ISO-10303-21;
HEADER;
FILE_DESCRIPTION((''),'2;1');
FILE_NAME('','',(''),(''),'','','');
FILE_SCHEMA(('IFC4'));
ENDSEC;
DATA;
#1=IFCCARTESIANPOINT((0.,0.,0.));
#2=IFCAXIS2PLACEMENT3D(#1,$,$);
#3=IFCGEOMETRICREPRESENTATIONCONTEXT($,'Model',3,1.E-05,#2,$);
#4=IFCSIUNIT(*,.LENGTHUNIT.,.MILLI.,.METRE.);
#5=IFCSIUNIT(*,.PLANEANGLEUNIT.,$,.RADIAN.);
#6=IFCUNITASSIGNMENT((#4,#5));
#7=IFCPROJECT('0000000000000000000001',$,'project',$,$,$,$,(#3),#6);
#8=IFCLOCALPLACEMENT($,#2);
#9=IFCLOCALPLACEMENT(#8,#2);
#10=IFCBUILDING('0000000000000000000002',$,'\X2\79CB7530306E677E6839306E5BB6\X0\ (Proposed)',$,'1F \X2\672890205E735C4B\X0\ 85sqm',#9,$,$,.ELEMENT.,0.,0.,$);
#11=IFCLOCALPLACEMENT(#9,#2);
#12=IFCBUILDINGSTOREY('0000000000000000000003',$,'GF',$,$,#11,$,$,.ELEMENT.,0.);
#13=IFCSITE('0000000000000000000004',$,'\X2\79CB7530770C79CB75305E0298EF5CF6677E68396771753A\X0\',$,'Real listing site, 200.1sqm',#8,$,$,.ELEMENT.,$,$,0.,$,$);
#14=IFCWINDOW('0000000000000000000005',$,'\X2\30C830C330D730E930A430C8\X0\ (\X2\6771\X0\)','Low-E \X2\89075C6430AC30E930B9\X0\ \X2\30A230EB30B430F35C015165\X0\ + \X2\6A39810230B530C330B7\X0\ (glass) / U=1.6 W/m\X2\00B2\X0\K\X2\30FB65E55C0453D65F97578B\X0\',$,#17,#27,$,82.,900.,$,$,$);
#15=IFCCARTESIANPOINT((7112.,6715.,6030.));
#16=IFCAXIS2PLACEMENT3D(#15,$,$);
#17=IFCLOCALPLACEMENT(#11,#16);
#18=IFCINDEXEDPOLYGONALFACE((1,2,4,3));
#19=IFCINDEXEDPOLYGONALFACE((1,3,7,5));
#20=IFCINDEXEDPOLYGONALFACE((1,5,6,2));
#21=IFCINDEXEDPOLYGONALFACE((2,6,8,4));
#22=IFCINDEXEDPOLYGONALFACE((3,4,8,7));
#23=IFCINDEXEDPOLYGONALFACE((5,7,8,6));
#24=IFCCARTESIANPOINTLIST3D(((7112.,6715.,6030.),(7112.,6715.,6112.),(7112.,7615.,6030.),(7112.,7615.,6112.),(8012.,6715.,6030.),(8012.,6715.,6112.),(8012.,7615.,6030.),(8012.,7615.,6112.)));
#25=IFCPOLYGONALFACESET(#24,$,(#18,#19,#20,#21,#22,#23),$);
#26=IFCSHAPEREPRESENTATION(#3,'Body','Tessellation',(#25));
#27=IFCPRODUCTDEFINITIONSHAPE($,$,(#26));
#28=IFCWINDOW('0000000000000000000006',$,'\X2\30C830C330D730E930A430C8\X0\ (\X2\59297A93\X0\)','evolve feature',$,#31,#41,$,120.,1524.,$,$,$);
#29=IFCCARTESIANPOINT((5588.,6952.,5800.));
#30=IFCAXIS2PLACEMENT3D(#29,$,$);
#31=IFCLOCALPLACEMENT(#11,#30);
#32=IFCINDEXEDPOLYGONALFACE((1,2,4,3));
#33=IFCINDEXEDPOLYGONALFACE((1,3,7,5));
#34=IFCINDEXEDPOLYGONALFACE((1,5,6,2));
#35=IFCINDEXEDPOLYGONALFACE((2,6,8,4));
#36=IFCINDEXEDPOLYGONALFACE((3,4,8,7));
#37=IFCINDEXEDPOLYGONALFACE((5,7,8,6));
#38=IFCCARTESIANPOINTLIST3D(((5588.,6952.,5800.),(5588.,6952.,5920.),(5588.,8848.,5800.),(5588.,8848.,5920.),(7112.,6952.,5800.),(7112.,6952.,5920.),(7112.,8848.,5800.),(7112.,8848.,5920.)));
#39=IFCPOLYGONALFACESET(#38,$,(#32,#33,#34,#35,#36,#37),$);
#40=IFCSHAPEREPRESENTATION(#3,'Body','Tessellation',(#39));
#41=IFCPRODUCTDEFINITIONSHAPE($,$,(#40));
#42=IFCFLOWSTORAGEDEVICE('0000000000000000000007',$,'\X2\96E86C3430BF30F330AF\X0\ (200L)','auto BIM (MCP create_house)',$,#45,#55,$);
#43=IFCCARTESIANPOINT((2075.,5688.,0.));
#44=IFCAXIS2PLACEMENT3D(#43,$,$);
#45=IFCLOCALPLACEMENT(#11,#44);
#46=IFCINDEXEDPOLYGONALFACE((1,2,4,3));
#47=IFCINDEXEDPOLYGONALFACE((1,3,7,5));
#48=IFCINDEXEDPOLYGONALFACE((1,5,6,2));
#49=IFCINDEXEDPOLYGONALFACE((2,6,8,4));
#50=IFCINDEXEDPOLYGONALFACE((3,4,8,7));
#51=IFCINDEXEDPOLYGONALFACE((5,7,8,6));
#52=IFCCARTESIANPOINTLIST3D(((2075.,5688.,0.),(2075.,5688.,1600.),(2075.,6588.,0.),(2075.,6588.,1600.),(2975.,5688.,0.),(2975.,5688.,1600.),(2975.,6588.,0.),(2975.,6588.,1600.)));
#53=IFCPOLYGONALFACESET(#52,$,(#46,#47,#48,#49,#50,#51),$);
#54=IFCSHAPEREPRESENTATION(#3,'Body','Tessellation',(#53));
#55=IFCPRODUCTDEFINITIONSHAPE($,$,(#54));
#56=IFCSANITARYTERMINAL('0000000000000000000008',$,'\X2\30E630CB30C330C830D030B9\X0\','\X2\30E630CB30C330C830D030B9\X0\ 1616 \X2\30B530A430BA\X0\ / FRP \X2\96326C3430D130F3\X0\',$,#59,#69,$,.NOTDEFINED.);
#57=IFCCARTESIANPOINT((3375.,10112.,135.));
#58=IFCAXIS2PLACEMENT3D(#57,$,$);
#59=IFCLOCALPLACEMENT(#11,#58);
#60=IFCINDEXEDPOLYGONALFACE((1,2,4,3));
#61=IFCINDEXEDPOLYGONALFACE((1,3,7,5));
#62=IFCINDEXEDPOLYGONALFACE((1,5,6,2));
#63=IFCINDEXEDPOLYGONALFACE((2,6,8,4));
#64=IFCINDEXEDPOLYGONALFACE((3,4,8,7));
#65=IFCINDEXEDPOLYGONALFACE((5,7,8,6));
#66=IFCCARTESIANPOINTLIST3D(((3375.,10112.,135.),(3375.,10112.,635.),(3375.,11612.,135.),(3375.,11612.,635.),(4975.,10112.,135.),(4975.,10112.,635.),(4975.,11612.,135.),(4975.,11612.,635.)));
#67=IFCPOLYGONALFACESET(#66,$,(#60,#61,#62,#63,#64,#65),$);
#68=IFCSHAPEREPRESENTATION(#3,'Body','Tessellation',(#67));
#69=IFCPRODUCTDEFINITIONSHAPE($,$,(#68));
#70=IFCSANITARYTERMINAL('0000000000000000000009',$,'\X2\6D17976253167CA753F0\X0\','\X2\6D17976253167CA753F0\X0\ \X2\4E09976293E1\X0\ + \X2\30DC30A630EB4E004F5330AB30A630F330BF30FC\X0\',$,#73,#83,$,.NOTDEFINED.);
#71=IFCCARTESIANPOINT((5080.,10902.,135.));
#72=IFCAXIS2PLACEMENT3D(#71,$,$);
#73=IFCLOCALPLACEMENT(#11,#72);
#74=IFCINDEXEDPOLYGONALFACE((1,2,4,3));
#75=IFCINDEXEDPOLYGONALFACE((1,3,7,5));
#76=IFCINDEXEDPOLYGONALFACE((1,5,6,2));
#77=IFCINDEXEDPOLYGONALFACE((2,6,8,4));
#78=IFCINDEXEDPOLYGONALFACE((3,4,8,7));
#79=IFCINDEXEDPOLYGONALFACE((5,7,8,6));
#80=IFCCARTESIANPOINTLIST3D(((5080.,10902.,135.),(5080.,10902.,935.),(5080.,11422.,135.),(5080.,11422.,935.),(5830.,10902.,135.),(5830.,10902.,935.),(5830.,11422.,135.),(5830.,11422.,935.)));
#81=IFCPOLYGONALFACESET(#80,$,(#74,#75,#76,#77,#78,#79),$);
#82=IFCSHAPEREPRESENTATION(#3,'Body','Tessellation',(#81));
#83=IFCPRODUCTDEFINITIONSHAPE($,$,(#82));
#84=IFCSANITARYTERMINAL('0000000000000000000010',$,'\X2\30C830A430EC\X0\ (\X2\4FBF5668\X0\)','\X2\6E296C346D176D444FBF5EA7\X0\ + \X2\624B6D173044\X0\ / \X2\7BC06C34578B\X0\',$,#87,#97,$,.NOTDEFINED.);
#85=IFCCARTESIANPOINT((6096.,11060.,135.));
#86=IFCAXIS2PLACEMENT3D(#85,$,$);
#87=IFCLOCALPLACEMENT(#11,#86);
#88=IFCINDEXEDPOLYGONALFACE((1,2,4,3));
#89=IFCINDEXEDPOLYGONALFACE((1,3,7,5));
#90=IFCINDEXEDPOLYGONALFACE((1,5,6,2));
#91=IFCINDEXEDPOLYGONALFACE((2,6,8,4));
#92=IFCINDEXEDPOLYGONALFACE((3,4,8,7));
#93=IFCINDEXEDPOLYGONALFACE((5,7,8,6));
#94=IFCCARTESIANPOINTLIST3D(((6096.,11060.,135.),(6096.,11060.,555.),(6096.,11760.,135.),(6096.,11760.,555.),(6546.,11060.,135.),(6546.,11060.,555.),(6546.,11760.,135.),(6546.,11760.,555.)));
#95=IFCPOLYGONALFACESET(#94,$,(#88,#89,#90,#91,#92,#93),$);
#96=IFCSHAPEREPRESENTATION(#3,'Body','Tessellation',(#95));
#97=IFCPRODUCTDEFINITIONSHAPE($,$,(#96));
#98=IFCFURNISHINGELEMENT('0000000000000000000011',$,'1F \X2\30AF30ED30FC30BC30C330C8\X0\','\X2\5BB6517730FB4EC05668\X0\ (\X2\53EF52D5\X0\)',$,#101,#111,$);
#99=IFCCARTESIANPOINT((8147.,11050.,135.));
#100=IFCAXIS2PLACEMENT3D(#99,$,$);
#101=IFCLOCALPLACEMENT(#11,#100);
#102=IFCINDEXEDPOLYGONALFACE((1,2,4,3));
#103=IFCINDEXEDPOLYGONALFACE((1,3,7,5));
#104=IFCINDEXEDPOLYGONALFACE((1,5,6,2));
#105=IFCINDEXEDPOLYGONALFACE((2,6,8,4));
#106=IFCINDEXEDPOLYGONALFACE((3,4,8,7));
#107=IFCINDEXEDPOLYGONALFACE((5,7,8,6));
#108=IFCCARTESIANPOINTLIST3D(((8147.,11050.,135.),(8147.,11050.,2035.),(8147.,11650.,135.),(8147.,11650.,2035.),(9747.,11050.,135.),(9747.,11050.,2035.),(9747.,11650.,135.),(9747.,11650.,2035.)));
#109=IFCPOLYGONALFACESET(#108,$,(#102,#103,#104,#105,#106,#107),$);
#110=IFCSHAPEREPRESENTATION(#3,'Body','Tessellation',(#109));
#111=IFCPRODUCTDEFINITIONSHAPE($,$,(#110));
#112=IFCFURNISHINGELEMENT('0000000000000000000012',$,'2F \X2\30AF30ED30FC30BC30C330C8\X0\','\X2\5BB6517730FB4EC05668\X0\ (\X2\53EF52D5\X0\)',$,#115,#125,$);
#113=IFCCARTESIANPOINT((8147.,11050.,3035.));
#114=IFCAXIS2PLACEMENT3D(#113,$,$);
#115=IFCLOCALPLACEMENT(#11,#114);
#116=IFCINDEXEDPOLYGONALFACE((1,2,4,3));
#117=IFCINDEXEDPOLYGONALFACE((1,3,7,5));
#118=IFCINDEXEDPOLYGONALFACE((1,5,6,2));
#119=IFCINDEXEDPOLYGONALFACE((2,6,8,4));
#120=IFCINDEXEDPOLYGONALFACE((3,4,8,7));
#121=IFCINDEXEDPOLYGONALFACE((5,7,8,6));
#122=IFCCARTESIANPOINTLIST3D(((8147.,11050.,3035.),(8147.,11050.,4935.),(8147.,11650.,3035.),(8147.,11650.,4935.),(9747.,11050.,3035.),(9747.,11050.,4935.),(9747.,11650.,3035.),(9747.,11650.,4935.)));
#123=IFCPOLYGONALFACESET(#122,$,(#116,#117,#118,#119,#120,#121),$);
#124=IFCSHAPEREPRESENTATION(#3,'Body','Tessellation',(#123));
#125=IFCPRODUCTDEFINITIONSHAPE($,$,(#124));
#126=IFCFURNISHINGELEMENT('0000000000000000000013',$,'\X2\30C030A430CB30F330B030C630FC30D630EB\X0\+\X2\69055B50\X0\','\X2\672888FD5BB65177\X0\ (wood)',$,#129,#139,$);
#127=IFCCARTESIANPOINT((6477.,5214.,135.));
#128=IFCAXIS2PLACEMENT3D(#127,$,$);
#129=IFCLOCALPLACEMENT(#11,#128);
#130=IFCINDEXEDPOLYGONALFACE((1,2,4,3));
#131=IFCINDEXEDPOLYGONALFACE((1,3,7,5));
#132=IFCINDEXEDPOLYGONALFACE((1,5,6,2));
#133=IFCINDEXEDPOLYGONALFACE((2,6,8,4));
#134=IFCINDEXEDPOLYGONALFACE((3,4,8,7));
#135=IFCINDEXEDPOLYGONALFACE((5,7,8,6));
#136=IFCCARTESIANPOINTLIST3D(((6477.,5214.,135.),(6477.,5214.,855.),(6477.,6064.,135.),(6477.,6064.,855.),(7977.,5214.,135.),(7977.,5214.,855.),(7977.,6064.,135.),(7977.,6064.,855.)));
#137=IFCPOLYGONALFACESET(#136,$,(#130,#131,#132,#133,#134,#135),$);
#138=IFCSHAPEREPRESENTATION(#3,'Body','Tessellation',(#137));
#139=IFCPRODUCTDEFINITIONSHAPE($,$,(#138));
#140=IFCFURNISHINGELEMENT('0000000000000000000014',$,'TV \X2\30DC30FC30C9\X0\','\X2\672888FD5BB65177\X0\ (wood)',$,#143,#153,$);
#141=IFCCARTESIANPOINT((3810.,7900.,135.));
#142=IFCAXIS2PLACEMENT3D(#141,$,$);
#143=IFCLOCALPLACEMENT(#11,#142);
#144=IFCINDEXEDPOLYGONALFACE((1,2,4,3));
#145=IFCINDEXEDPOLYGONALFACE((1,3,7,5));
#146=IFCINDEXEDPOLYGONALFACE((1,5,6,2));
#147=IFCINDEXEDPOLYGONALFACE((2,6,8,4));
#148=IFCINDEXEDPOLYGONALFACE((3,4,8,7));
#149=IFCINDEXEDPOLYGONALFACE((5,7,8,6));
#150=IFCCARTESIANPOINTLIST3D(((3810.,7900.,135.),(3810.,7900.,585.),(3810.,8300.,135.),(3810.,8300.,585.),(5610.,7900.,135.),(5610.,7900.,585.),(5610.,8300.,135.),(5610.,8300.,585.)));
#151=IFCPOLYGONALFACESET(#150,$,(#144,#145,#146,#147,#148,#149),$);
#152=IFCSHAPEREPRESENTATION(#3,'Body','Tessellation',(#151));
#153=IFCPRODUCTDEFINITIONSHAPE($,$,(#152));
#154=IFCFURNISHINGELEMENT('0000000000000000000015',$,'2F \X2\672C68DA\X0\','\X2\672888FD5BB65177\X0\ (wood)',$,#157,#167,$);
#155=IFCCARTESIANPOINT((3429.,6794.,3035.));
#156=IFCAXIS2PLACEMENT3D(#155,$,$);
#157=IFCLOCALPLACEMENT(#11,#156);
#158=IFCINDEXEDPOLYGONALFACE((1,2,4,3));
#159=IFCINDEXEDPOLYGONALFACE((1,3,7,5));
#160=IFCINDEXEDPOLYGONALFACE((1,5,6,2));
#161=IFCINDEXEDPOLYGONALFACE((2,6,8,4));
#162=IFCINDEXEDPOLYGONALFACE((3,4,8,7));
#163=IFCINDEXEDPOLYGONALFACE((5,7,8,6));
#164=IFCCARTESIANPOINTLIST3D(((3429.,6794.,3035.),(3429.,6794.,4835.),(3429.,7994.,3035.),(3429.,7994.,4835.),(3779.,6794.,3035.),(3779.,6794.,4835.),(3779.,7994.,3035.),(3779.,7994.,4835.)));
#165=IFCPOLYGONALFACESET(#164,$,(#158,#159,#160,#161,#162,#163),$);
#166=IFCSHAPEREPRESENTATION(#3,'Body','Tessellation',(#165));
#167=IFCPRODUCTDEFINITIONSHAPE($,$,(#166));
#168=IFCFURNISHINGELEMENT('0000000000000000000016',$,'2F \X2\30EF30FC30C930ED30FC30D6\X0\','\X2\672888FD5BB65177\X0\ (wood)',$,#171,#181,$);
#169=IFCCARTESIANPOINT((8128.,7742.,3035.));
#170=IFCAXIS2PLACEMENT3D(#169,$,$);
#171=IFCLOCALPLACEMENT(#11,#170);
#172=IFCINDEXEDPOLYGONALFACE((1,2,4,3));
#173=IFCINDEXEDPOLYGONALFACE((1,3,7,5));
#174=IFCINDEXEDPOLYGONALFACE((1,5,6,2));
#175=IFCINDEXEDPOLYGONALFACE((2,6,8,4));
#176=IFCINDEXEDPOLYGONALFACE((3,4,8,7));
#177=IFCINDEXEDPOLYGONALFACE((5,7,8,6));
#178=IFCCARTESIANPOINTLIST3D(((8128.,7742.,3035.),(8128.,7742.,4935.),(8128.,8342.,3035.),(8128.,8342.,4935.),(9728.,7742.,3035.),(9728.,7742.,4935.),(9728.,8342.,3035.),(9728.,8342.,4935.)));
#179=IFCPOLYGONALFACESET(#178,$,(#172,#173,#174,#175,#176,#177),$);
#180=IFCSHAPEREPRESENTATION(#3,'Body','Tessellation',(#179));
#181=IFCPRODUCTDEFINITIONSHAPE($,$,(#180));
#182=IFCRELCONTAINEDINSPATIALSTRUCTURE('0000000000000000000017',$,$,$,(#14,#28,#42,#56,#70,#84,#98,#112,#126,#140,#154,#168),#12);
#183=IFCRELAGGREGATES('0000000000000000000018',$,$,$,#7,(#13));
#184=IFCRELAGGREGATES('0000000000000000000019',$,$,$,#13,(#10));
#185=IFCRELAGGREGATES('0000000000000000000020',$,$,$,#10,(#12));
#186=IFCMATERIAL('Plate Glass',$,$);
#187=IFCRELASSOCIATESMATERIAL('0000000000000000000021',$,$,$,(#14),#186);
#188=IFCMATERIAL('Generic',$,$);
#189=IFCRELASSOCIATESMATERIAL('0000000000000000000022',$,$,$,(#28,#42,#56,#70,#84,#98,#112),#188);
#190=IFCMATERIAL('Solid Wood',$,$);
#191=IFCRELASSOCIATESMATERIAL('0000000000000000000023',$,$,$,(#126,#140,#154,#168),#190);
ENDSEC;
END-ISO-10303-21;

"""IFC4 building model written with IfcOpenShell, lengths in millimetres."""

from ifc_helpers import new_model, si_unit, frame, frame_2d, origin, place, context, project, spatial, rectangle, extrude, material, element, save


model = new_model("IFC4")

# Units and contexts
model_context = context("Model", 3, precision=1e-05, world=origin())
ifc_project = project(units=[si_unit("LENGTHUNIT", "METRE", prefix="MILLI"), si_unit("PLANEANGLEUNIT", "RADIAN")], contexts=[model_context])

# Site, building, storey
site_placement = place(None, origin())
site = spatial("IfcSite", under=ifc_project, at=site_placement, Name="秋田県秋田市飯島松根東町", ObjectType="Real listing site, 200.1sqm", CompositionType="ELEMENT", RefElevation=0.0)
building_placement = place(site_placement, origin())
building = spatial("IfcBuilding", under=site, at=building_placement, Name="秋田の松根の家 (Proposed)", ObjectType="1F 木造平屋 85sqm", CompositionType="ELEMENT", ElevationOfRefHeight=0.0, ElevationOfTerrain=0.0)
storey_placement = place(building_placement, origin())
storey = spatial("IfcBuildingStorey", under=building, at=storey_placement, Name="GF", CompositionType="ELEMENT", Elevation=0.0)

# Shared definitions
ifc_material_1 = material(Name="Solid Wood")
ifc_material_2 = material(Name="Plate Glass")

# Windows
window_1_placement = place(storey_placement, frame((7112.0, 6715.0, 6030.0)))
element("IfcWindow", 1, at=window_1_placement, inside=storey, material=ifc_material_2, Name="トップライト (東)", Description="Low-E 複層ガラス アルゴン封入 + 樹脂サッシ (glass) / U=1.6 W/m²K・日射取得型", OverallHeight=82.0, OverallWidth=900.0, context=model_context, shape_type="SweptSolid", body=[
    extrude(rectangle(XDim=900.0, YDim=900.0, at=frame_2d((450.0, 450.0))), frame((7112.0, 6715.0, 6030.0)), (0.0, 0.0, 1.0), 82.0),
])
ifc_material_3 = material(Name="Generic")
window_2_placement = place(storey_placement, frame((5588.0, 6952.0, 5800.0)))
element("IfcWindow", 2, at=window_2_placement, inside=storey, material=ifc_material_3, Name="トップライト (天窓)", Description="evolve feature", OverallHeight=120.0, OverallWidth=1524.0, context=model_context, shape_type="SweptSolid", body=[
    extrude(rectangle(XDim=1524.0, YDim=1896.0, at=frame_2d((762.0, 948.0))), frame((5588.0, 6952.0, 5800.0)), (0.0, 0.0, 1.0), 120.0),
])

# Flow storage device
flow_storage_device_placement = place(storey_placement, frame((2075.0, 5688.0, 0.0)))
element("IfcFlowStorageDevice", 3, at=flow_storage_device_placement, inside=storey, material=ifc_material_3, Name="雨水タンク (200L)", Description="auto BIM (MCP create_house)", context=model_context, shape_type="SweptSolid", body=[
    extrude(rectangle(XDim=900.0, YDim=900.0, at=frame_2d((450.0, 450.0))), frame((2075.0, 5688.0, 0.0)), (0.0, 0.0, 1.0), 1600.0),
])

# Sanitary terminals
sanitary_terminal_1_placement = place(storey_placement, frame((3375.0, 10112.0, 135.0)))
element("IfcSanitaryTerminal", 4, at=sanitary_terminal_1_placement, inside=storey, material=ifc_material_3, Name="ユニットバス", Description="ユニットバス 1616 サイズ / FRP 防水パン", PredefinedType="NOTDEFINED", context=model_context, shape_type="SweptSolid", body=[
    extrude(rectangle(XDim=1600.0, YDim=1500.0, at=frame_2d((800.0, 750.0))), frame((3375.0, 10112.0, 135.0)), (0.0, 0.0, 1.0), 500.0),
])
sanitary_terminal_2_placement = place(storey_placement, frame((5080.0, 10902.0, 135.0)))
element("IfcSanitaryTerminal", 5, at=sanitary_terminal_2_placement, inside=storey, material=ifc_material_3, Name="洗面化粧台", Description="洗面化粧台 三面鏡 + ボウル一体カウンター", PredefinedType="NOTDEFINED", context=model_context, shape_type="SweptSolid", body=[
    extrude(rectangle(XDim=750.0, YDim=520.0, at=frame_2d((375.0, 260.0))), frame((5080.0, 10902.0, 135.0)), (0.0, 0.0, 1.0), 800.0),
])
sanitary_terminal_3_placement = place(storey_placement, frame((6096.0, 11060.0, 135.0)))
element("IfcSanitaryTerminal", 6, at=sanitary_terminal_3_placement, inside=storey, material=ifc_material_3, Name="トイレ (便器)", Description="温水洗浄便座 + 手洗い / 節水型", PredefinedType="NOTDEFINED", context=model_context, shape_type="SweptSolid", body=[
    extrude(rectangle(XDim=450.0, YDim=700.0, at=frame_2d((225.0, 350.0))), frame((6096.0, 11060.0, 135.0)), (0.0, 0.0, 1.0), 420.0),
])

# Furnishing elements
furnishing_1_placement = place(storey_placement, frame((8147.0, 11050.0, 135.0)))
element("IfcFurnishingElement", 7, at=furnishing_1_placement, inside=storey, material=ifc_material_3, Name="1F クローゼット", Description="家具・什器 (可動)", context=model_context, shape_type="SweptSolid", body=[
    extrude(rectangle(XDim=1600.0, YDim=600.0, at=frame_2d((800.0, 300.0))), frame((8147.0, 11050.0, 135.0)), (0.0, 0.0, 1.0), 1900.0),
])
furnishing_2_placement = place(storey_placement, frame((8147.0, 11050.0, 3035.0)))
element("IfcFurnishingElement", 8, at=furnishing_2_placement, inside=storey, material=ifc_material_3, Name="2F クローゼット", Description="家具・什器 (可動)", context=model_context, shape_type="SweptSolid", body=[
    extrude(rectangle(XDim=1600.0, YDim=600.0, at=frame_2d((800.0, 300.0))), frame((8147.0, 11050.0, 3035.0)), (0.0, 0.0, 1.0), 1900.0),
])
furnishing_3_placement = place(storey_placement, frame((6477.0, 5214.0, 135.0)))
element("IfcFurnishingElement", 9, at=furnishing_3_placement, inside=storey, material=ifc_material_1, Name="ダイニングテーブル+椅子", Description="木製家具 (wood)", context=model_context, shape_type="SweptSolid", body=[
    extrude(rectangle(XDim=1500.0, YDim=850.0, at=frame_2d((750.0, 425.0))), frame((6477.0, 5214.0, 135.0)), (0.0, 0.0, 1.0), 720.0),
])
furnishing_4_placement = place(storey_placement, frame((3810.0, 7900.0, 135.0)))
element("IfcFurnishingElement", 10, at=furnishing_4_placement, inside=storey, material=ifc_material_1, Name="TV ボード", Description="木製家具 (wood)", context=model_context, shape_type="SweptSolid", body=[
    extrude(rectangle(XDim=1800.0, YDim=400.0, at=frame_2d((900.0, 200.0))), frame((3810.0, 7900.0, 135.0)), (0.0, 0.0, 1.0), 450.0),
])
furnishing_5_placement = place(storey_placement, frame((3429.0, 6794.0, 3035.0)))
element("IfcFurnishingElement", 11, at=furnishing_5_placement, inside=storey, material=ifc_material_1, Name="2F 本棚", Description="木製家具 (wood)", context=model_context, shape_type="SweptSolid", body=[
    extrude(rectangle(XDim=350.0, YDim=1200.0, at=frame_2d((175.0, 600.0))), frame((3429.0, 6794.0, 3035.0)), (0.0, 0.0, 1.0), 1800.0),
])
furnishing_6_placement = place(storey_placement, frame((8128.0, 7742.0, 3035.0)))
element("IfcFurnishingElement", 12, at=furnishing_6_placement, inside=storey, material=ifc_material_1, Name="2F ワードローブ", Description="木製家具 (wood)", context=model_context, shape_type="SweptSolid", body=[
    extrude(rectangle(XDim=1600.0, YDim=600.0, at=frame_2d((800.0, 300.0))), frame((8128.0, 7742.0, 3035.0)), (0.0, 0.0, 1.0), 1900.0),
])

save(model, "model.ifc")
